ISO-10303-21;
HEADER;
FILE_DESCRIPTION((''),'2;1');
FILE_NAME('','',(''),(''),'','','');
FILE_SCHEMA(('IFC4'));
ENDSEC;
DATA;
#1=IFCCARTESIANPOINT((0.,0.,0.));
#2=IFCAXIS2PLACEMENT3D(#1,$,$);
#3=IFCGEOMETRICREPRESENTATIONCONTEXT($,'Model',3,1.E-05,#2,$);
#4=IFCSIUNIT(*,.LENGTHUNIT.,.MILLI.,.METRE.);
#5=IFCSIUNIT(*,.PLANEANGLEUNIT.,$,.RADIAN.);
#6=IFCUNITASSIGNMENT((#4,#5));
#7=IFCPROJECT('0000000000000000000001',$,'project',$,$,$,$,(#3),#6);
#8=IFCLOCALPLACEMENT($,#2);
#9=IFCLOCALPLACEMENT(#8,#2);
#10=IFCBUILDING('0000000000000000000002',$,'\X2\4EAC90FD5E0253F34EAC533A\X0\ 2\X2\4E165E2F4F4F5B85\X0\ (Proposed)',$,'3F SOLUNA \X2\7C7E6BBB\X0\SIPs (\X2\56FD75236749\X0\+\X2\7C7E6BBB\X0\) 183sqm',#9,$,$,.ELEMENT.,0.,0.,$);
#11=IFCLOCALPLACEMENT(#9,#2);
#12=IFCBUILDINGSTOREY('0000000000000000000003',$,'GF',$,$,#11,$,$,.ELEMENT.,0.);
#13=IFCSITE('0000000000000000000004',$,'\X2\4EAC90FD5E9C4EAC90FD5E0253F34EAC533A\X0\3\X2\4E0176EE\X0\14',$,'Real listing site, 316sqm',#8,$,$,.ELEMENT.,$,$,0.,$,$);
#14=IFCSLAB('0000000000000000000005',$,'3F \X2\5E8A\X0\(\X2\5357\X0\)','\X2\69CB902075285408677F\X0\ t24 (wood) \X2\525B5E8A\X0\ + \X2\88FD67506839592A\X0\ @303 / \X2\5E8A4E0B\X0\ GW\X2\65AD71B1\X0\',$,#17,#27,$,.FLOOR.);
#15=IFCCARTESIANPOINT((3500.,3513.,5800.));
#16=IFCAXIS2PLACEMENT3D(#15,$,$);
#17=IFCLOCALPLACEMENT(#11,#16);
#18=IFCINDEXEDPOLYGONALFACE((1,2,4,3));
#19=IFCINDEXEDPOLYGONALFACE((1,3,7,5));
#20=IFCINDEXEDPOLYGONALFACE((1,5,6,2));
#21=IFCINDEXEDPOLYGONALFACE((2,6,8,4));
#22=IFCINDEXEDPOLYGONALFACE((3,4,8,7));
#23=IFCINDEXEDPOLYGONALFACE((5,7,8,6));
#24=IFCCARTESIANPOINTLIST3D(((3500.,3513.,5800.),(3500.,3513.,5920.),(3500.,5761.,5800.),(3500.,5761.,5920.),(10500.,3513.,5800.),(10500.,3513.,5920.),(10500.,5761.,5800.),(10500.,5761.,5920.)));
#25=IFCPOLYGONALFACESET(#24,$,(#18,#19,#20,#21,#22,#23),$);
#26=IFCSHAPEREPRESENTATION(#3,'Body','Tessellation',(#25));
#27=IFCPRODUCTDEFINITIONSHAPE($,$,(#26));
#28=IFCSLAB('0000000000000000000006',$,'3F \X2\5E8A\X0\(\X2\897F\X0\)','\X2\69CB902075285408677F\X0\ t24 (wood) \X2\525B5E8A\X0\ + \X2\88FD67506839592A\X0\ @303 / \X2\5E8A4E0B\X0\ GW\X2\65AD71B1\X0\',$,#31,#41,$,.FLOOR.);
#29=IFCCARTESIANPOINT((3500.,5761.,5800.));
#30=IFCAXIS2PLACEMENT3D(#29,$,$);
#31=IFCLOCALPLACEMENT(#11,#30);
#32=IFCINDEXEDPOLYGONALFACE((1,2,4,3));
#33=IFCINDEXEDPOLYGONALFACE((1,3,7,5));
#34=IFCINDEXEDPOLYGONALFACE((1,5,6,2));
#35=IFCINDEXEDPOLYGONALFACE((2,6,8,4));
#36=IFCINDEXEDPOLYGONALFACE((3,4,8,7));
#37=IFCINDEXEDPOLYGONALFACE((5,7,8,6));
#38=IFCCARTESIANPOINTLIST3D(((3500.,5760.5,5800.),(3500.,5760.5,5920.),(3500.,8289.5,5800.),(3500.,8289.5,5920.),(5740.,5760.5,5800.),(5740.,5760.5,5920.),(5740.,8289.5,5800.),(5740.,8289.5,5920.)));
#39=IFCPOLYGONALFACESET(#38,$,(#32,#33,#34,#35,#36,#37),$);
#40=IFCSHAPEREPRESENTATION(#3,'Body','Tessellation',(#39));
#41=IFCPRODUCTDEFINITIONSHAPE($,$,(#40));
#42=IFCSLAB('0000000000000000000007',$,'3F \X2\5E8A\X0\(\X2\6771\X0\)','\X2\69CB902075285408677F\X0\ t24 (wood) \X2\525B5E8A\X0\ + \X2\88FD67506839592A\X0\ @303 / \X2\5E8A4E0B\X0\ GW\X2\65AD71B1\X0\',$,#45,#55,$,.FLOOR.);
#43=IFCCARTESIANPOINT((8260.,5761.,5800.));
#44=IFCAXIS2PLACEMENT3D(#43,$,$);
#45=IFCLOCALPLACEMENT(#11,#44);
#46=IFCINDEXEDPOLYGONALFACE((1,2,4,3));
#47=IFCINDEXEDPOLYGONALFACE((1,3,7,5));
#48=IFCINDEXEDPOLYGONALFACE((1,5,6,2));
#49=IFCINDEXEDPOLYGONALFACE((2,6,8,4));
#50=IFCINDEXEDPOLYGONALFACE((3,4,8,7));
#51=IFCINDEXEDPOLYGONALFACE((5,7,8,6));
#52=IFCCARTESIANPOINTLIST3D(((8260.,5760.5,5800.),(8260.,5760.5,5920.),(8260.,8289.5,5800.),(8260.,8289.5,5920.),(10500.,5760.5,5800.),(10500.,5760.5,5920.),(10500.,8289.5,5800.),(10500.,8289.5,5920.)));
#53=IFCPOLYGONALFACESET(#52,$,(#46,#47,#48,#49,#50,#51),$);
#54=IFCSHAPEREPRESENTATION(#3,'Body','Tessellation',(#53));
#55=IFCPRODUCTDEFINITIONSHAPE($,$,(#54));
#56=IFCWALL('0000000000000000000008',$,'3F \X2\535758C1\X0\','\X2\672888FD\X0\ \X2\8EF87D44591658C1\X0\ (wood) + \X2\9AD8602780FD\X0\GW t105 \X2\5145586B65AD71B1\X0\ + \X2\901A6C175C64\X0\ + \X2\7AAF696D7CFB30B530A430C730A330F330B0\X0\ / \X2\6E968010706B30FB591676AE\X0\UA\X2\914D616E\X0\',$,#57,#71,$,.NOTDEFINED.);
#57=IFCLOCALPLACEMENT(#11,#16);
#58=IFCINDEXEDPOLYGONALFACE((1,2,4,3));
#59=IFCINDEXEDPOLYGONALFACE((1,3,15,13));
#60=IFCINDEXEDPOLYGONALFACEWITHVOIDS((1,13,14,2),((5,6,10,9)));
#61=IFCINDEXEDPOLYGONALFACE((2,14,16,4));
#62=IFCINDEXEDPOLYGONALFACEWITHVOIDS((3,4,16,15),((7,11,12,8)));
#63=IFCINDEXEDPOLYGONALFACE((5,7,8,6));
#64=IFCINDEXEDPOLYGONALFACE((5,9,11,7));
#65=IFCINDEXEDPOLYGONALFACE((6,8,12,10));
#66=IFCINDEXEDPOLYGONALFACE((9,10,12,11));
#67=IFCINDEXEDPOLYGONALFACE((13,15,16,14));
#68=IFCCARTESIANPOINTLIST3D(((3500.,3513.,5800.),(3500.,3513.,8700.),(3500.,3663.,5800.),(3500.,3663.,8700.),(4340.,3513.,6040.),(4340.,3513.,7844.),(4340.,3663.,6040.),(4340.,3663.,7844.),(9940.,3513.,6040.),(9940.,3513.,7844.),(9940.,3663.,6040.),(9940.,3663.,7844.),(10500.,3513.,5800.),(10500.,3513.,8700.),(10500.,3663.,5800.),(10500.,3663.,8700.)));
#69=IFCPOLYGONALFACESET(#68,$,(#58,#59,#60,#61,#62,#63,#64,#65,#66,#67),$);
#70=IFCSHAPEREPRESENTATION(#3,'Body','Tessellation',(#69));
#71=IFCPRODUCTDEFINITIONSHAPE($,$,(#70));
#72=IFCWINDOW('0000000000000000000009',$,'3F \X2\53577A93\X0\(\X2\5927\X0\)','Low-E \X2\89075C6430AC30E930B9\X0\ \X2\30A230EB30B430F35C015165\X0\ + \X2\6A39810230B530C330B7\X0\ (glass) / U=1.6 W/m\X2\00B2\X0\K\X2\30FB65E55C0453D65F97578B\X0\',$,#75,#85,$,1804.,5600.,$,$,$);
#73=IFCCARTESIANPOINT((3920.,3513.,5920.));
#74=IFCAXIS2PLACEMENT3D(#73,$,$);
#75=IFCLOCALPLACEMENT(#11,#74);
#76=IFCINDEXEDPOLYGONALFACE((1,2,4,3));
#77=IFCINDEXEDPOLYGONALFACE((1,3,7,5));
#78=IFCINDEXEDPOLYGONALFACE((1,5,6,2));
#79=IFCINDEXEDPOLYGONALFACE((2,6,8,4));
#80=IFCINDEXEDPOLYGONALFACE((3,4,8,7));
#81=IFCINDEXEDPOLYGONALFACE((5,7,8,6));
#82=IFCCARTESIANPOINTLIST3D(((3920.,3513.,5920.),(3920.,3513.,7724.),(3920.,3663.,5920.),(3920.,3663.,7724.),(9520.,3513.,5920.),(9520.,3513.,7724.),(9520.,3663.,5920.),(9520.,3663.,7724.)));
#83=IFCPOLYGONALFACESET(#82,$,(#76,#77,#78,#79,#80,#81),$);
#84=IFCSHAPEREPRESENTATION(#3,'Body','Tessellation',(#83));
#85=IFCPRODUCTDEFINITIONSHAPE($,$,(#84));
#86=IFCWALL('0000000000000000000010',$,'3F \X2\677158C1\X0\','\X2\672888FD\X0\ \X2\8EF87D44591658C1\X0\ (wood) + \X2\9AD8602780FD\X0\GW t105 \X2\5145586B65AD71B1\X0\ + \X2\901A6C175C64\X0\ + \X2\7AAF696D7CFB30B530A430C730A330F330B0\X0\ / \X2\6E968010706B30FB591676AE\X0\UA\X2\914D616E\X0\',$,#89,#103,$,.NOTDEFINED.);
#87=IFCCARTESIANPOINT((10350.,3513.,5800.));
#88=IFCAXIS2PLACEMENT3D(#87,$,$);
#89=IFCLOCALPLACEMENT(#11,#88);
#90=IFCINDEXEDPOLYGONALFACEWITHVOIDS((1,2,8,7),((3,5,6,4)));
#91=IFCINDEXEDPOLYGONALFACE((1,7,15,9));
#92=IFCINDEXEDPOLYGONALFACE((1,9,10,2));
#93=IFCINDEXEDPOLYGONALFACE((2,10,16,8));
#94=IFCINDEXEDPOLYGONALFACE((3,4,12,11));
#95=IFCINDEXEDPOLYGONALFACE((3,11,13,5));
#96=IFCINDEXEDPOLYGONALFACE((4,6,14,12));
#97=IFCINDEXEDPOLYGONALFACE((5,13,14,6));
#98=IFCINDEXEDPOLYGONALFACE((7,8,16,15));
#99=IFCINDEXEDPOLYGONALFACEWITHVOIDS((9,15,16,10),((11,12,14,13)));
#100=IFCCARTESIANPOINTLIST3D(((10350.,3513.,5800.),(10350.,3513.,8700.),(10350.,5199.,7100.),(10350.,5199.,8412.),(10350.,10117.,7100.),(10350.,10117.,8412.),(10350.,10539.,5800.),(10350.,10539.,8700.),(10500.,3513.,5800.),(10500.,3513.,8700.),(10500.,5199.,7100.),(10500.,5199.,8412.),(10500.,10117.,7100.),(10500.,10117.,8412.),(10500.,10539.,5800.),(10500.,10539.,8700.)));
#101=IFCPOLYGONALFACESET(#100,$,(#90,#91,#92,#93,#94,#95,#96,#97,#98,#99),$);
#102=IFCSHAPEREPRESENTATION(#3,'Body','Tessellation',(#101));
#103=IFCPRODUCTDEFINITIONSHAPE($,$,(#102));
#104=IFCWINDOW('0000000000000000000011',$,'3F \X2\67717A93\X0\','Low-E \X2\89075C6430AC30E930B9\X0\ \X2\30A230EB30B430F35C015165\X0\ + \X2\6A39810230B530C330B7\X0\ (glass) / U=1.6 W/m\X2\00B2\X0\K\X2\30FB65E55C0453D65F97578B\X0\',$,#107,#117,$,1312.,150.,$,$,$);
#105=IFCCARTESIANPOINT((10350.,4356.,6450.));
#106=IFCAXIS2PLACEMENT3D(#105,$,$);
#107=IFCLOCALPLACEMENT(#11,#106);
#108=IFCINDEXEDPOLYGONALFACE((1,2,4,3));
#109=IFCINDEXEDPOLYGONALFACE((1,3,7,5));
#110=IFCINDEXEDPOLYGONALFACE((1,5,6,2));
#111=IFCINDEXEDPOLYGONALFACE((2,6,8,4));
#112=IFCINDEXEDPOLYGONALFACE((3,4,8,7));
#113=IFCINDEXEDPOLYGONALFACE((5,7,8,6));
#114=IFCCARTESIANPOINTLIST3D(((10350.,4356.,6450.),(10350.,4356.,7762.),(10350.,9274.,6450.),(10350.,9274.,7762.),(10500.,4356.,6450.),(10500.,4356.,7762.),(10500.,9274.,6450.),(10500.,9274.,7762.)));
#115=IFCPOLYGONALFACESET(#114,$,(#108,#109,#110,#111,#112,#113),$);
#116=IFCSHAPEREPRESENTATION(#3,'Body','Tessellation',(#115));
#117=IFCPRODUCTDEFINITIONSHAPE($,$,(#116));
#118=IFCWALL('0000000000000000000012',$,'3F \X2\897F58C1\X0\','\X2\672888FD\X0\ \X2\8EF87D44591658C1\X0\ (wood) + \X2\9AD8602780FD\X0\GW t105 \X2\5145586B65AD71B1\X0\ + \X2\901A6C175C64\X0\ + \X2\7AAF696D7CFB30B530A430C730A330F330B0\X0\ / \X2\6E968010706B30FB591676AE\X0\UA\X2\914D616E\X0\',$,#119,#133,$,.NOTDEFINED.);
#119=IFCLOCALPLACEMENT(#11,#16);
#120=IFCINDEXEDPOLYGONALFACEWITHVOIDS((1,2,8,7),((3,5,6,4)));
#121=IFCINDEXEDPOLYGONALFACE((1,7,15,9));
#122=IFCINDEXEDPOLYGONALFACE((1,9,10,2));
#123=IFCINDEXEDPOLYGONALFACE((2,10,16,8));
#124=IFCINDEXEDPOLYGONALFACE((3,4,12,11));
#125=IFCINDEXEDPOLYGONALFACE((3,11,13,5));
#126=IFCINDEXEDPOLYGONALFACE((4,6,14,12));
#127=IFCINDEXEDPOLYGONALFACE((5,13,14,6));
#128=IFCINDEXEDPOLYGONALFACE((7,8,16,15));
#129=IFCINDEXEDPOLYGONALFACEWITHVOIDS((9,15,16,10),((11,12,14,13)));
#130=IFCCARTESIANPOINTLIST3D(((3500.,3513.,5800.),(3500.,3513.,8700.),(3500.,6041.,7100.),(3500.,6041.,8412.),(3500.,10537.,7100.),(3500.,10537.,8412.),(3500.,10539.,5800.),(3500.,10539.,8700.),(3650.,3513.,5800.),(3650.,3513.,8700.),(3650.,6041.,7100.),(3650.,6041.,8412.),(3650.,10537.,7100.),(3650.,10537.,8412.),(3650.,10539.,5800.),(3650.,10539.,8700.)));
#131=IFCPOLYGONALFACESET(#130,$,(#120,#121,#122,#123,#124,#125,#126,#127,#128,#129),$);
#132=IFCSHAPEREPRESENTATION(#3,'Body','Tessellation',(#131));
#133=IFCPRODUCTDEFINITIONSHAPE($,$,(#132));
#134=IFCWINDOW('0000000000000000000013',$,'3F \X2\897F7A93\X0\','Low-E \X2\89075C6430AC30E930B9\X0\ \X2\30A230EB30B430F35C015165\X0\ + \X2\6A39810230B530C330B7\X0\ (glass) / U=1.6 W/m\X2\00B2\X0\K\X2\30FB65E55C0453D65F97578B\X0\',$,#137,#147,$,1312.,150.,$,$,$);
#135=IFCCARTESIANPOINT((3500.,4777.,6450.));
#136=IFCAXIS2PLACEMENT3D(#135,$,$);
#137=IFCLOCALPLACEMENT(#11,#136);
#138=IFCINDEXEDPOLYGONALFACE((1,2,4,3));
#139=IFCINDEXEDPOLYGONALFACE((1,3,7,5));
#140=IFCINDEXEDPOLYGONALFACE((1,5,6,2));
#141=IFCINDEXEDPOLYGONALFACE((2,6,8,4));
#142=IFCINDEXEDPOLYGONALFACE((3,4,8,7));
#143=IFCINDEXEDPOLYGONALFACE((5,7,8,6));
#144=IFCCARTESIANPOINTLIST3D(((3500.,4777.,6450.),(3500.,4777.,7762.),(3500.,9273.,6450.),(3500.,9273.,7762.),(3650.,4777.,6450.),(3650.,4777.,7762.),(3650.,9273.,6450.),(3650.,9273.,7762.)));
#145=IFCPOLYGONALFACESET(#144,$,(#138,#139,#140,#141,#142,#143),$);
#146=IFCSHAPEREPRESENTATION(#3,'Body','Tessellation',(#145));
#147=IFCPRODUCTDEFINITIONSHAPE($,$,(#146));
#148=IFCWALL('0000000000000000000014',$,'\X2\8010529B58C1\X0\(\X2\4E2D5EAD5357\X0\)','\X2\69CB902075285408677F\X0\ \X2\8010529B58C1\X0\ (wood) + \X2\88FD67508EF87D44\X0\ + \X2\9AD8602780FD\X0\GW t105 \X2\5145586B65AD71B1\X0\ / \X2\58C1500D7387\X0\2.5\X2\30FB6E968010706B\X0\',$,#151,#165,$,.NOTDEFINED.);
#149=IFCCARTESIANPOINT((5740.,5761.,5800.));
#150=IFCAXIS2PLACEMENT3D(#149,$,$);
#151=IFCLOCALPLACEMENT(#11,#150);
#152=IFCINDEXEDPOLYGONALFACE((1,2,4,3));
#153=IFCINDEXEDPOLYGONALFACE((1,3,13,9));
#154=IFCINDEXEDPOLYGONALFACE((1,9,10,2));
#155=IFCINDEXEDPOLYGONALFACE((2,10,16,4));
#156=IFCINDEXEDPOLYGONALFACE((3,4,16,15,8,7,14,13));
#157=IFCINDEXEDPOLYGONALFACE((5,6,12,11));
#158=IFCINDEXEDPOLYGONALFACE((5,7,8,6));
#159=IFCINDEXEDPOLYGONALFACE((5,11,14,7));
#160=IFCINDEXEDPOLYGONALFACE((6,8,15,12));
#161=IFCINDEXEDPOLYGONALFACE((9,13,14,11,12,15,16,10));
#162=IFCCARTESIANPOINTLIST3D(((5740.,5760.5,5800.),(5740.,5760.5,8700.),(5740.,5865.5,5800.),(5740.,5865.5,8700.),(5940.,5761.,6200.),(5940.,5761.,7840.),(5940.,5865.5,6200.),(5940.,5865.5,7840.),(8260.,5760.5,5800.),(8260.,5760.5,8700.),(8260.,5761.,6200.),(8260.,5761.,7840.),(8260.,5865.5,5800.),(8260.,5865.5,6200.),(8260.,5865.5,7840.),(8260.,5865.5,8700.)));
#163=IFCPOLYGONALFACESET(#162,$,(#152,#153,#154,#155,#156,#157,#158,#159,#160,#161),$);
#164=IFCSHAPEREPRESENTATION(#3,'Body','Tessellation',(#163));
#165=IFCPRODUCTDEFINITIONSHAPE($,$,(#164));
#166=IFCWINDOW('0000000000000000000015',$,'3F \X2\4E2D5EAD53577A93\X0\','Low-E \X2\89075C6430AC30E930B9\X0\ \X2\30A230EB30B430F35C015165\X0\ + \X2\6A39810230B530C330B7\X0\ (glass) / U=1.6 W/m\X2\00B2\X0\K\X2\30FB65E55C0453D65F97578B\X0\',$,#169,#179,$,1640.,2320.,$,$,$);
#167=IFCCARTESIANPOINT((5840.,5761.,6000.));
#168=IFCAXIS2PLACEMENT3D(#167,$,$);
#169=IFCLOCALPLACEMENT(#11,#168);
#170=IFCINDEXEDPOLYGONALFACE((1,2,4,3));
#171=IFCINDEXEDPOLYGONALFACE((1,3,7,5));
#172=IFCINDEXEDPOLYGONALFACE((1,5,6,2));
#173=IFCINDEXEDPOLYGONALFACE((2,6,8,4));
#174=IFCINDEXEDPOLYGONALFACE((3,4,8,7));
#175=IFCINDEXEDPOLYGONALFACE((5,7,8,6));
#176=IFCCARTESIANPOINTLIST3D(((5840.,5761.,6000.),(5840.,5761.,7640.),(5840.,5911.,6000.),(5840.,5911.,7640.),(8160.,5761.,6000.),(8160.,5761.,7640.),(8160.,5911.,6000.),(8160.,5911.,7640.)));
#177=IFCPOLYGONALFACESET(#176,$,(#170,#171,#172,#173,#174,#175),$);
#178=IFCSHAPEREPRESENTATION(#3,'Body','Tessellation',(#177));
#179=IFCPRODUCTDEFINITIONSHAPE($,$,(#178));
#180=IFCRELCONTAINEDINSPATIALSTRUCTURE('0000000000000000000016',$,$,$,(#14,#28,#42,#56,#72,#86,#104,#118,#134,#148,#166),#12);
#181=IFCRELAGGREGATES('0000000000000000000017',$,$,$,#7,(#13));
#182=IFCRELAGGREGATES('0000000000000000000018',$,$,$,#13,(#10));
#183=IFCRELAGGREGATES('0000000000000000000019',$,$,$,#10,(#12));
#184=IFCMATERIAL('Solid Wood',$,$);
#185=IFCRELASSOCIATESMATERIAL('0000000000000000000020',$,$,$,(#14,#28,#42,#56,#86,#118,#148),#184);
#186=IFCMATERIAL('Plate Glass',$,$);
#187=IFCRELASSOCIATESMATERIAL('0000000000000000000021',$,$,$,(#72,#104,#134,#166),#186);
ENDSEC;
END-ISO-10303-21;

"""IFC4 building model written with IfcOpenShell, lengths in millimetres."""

from ifc_helpers import new_model, si_unit, frame, frame_2d, origin, place, context, project, spatial, rectangle, extrude, material, element, fill, save


model = new_model("IFC4")

# Units and contexts
model_context = context("Model", 3, precision=1e-05, world=origin())
ifc_project = project(units=[si_unit("LENGTHUNIT", "METRE", prefix="MILLI"), si_unit("PLANEANGLEUNIT", "RADIAN")], contexts=[model_context])

# Site, building, storey
site_placement = place(None, origin())
site = spatial("IfcSite", under=ifc_project, at=site_placement, Name="京都府京都市右京区3丁目14", ObjectType="Real listing site, 316sqm", CompositionType="ELEMENT", RefElevation=0.0)
building_placement = place(site_placement, origin())
building = spatial("IfcBuilding", under=site, at=building_placement, Name="京都市右京区 2世帯住宅 (Proposed)", ObjectType="3F SOLUNA 籾殻SIPs (国産杉+籾殻) 183sqm", CompositionType="ELEMENT", ElevationOfRefHeight=0.0, ElevationOfTerrain=0.0)
storey_placement = place(building_placement, origin())
storey = spatial("IfcBuildingStorey", under=building, at=storey_placement, Name="GF", CompositionType="ELEMENT", Elevation=0.0)

# Slabs
ifc_material_1 = material(Name="Solid Wood")
slab_1_placement = place(storey_placement, frame((3500.0, 3513.0, 5800.0)))
element("IfcSlab", 1, at=slab_1_placement, inside=storey, material=ifc_material_1, Name="3F 床(南)", Description="構造用合板 t24 (wood) 剛床 + 製材根太 @303 / 床下 GW断熱", PredefinedType="FLOOR", context=model_context, shape_type="SweptSolid", body=[
    extrude(rectangle(XDim=7000.0, YDim=2248.0, at=frame_2d((3500.0, 1124.0))), frame((3500.0, 3513.0, 5800.0)), (0.0, 0.0, 1.0), 120.0),
])
slab_2_placement = place(storey_placement, frame((3500.0, 5761.0, 5800.0)))
element("IfcSlab", 2, at=slab_2_placement, inside=storey, material=ifc_material_1, Name="3F 床(西)", Description="構造用合板 t24 (wood) 剛床 + 製材根太 @303 / 床下 GW断熱", PredefinedType="FLOOR", context=model_context, shape_type="SweptSolid", body=[
    extrude(rectangle(XDim=2240.0, YDim=2529.0, at=frame_2d((1120.0, 1264.0))), frame((3500.0, 5761.0, 5800.0)), (0.0, 0.0, 1.0), 120.0),
])
slab_3_placement = place(storey_placement, frame((8260.0, 5761.0, 5800.0)))
element("IfcSlab", 3, at=slab_3_placement, inside=storey, material=ifc_material_1, Name="3F 床(東)", Description="構造用合板 t24 (wood) 剛床 + 製材根太 @303 / 床下 GW断熱", PredefinedType="FLOOR", context=model_context, shape_type="SweptSolid", body=[
    extrude(rectangle(XDim=2240.0, YDim=2529.0, at=frame_2d((1120.0, 1264.0))), frame((8260.0, 5761.0, 5800.0)), (0.0, 0.0, 1.0), 120.0),
])

# Walls, openings, windows
wall_1_placement = place(storey_placement, frame((3500.0, 3513.0, 5800.0)))
wall_1 = element("IfcWall", 4, at=wall_1_placement, inside=storey, material=ifc_material_1, Name="3F 南壁", Description="木製 軸組外壁 (wood) + 高性能GW t105 充填断熱 + 通気層 + 窯業系サイディング / 準耐火・外皮UA配慮", PredefinedType="NOTDEFINED", context=model_context, shape_type="SweptSolid", body=[
    extrude(rectangle(XDim=7000.0, YDim=150.0, at=frame_2d((3500.0, 75.0))), frame((3500.0, 3513.0, 5800.0)), (0.0, 0.0, 1.0), 2900.0),
])
opening_1_placement = place(storey_placement, frame((3920.0, 3513.0, 5920.0)))
opening_1 = element("IfcOpeningElement", 5, at=opening_1_placement, cuts=wall_1, PredefinedType="NOTDEFINED", context=model_context, shape_type="SweptSolid", body=[
    extrude(rectangle(XDim=5600.0, YDim=150.0, at=frame_2d((2800.0, 75.0))), frame((3920.0, 3513.0, 5920.0)), (0.0, 0.0, 1.0), 1804.0),
])
ifc_material_2 = material(Name="Plate Glass")
window_1_placement = place(storey_placement, frame((3920.0, 3513.0, 5920.0)))
window_1 = element("IfcWindow", 6, at=window_1_placement, inside=storey, material=ifc_material_2, Name="3F 南窓(大)", Description="Low-E 複層ガラス アルゴン封入 + 樹脂サッシ (glass) / U=1.6 W/m²K・日射取得型", OverallHeight=1804.0, OverallWidth=5600.0, context=model_context, shape_type="SweptSolid", body=[
    extrude(rectangle(XDim=5600.0, YDim=150.0, at=frame_2d((2800.0, 75.0))), frame((3920.0, 3513.0, 5920.0)), (0.0, 0.0, 1.0), 1804.0),
])
fill(opening_1, window_1)
wall_2_placement = place(storey_placement, frame((10350.0, 3513.0, 5800.0)))
wall_2 = element("IfcWall", 7, at=wall_2_placement, inside=storey, material=ifc_material_1, Name="3F 東壁", Description="木製 軸組外壁 (wood) + 高性能GW t105 充填断熱 + 通気層 + 窯業系サイディング / 準耐火・外皮UA配慮", PredefinedType="NOTDEFINED", context=model_context, shape_type="SweptSolid", body=[
    extrude(rectangle(XDim=150.0, YDim=7026.0, at=frame_2d((75.0, 3513.0))), frame((10350.0, 3513.0, 5800.0)), (0.0, 0.0, 1.0), 2900.0),
])
opening_2_placement = place(storey_placement, frame((10350.0, 4356.0, 6450.0)))
opening_2 = element("IfcOpeningElement", 8, at=opening_2_placement, cuts=wall_2, PredefinedType="NOTDEFINED", context=model_context, shape_type="SweptSolid", body=[
    extrude(rectangle(XDim=150.0, YDim=4918.0, at=frame_2d((75.0, 2459.0))), frame((10350.0, 4356.0, 6450.0)), (0.0, 0.0, 1.0), 1312.0),
])
window_2_placement = place(storey_placement, frame((10350.0, 4356.0, 6450.0)))
window_2 = element("IfcWindow", 9, at=window_2_placement, inside=storey, material=ifc_material_2, Name="3F 東窓", Description="Low-E 複層ガラス アルゴン封入 + 樹脂サッシ (glass) / U=1.6 W/m²K・日射取得型", OverallHeight=1312.0, OverallWidth=150.0, context=model_context, shape_type="SweptSolid", body=[
    extrude(rectangle(XDim=150.0, YDim=4918.0, at=frame_2d((75.0, 2459.0))), frame((10350.0, 4356.0, 6450.0)), (0.0, 0.0, 1.0), 1312.0),
])
fill(opening_2, window_2)
wall_3_placement = place(storey_placement, frame((3500.0, 3513.0, 5800.0)))
wall_3 = element("IfcWall", 10, at=wall_3_placement, inside=storey, material=ifc_material_1, Name="3F 西壁", Description="木製 軸組外壁 (wood) + 高性能GW t105 充填断熱 + 通気層 + 窯業系サイディング / 準耐火・外皮UA配慮", PredefinedType="NOTDEFINED", context=model_context, shape_type="SweptSolid", body=[
    extrude(rectangle(XDim=150.0, YDim=7026.0, at=frame_2d((75.0, 3513.0))), frame((3500.0, 3513.0, 5800.0)), (0.0, 0.0, 1.0), 2900.0),
])
opening_3_placement = place(storey_placement, frame((3500.0, 4777.0, 6450.0)))
opening_3 = element("IfcOpeningElement", 11, at=opening_3_placement, cuts=wall_3, PredefinedType="NOTDEFINED", context=model_context, shape_type="SweptSolid", body=[
    extrude(rectangle(XDim=150.0, YDim=4496.0, at=frame_2d((75.0, 2248.0))), frame((3500.0, 4777.0, 6450.0)), (0.0, 0.0, 1.0), 1312.0),
])
window_3_placement = place(storey_placement, frame((3500.0, 4777.0, 6450.0)))
window_3 = element("IfcWindow", 12, at=window_3_placement, inside=storey, material=ifc_material_2, Name="3F 西窓", Description="Low-E 複層ガラス アルゴン封入 + 樹脂サッシ (glass) / U=1.6 W/m²K・日射取得型", OverallHeight=1312.0, OverallWidth=150.0, context=model_context, shape_type="SweptSolid", body=[
    extrude(rectangle(XDim=150.0, YDim=4496.0, at=frame_2d((75.0, 2248.0))), frame((3500.0, 4777.0, 6450.0)), (0.0, 0.0, 1.0), 1312.0),
])
fill(opening_3, window_3)
wall_4_placement = place(storey_placement, frame((5740.0, 5761.0, 5800.0)))
wall_4 = element("IfcWall", 13, at=wall_4_placement, inside=storey, material=ifc_material_1, Name="耐力壁(中庭南)", Description="構造用合板 耐力壁 (wood) + 製材軸組 + 高性能GW t105 充填断熱 / 壁倍率2.5・準耐火", PredefinedType="NOTDEFINED", context=model_context, shape_type="SweptSolid", body=[
    extrude(rectangle(XDim=2520.0, YDim=105.0, at=frame_2d((1260.0, 52.0))), frame((5740.0, 5761.0, 5800.0)), (0.0, 0.0, 1.0), 2900.0),
])
opening_4_placement = place(storey_placement, frame((5840.0, 5761.0, 6000.0)))
opening_4 = element("IfcOpeningElement", 14, at=opening_4_placement, cuts=wall_4, PredefinedType="NOTDEFINED", context=model_context, shape_type="SweptSolid", body=[
    extrude(rectangle(XDim=2320.0, YDim=150.0, at=frame_2d((1160.0, 75.0))), frame((5840.0, 5761.0, 6000.0)), (0.0, 0.0, 1.0), 1640.0),
])
window_4_placement = place(storey_placement, frame((5840.0, 5761.0, 6000.0)))
window_4 = element("IfcWindow", 15, at=window_4_placement, inside=storey, material=ifc_material_2, Name="3F 中庭南窓", Description="Low-E 複層ガラス アルゴン封入 + 樹脂サッシ (glass) / U=1.6 W/m²K・日射取得型", OverallHeight=1640.0, OverallWidth=2320.0, context=model_context, shape_type="SweptSolid", body=[
    extrude(rectangle(XDim=2320.0, YDim=150.0, at=frame_2d((1160.0, 75.0))), frame((5840.0, 5761.0, 6000.0)), (0.0, 0.0, 1.0), 1640.0),
])
fill(opening_4, window_4)

save(model, "model.ifc")
